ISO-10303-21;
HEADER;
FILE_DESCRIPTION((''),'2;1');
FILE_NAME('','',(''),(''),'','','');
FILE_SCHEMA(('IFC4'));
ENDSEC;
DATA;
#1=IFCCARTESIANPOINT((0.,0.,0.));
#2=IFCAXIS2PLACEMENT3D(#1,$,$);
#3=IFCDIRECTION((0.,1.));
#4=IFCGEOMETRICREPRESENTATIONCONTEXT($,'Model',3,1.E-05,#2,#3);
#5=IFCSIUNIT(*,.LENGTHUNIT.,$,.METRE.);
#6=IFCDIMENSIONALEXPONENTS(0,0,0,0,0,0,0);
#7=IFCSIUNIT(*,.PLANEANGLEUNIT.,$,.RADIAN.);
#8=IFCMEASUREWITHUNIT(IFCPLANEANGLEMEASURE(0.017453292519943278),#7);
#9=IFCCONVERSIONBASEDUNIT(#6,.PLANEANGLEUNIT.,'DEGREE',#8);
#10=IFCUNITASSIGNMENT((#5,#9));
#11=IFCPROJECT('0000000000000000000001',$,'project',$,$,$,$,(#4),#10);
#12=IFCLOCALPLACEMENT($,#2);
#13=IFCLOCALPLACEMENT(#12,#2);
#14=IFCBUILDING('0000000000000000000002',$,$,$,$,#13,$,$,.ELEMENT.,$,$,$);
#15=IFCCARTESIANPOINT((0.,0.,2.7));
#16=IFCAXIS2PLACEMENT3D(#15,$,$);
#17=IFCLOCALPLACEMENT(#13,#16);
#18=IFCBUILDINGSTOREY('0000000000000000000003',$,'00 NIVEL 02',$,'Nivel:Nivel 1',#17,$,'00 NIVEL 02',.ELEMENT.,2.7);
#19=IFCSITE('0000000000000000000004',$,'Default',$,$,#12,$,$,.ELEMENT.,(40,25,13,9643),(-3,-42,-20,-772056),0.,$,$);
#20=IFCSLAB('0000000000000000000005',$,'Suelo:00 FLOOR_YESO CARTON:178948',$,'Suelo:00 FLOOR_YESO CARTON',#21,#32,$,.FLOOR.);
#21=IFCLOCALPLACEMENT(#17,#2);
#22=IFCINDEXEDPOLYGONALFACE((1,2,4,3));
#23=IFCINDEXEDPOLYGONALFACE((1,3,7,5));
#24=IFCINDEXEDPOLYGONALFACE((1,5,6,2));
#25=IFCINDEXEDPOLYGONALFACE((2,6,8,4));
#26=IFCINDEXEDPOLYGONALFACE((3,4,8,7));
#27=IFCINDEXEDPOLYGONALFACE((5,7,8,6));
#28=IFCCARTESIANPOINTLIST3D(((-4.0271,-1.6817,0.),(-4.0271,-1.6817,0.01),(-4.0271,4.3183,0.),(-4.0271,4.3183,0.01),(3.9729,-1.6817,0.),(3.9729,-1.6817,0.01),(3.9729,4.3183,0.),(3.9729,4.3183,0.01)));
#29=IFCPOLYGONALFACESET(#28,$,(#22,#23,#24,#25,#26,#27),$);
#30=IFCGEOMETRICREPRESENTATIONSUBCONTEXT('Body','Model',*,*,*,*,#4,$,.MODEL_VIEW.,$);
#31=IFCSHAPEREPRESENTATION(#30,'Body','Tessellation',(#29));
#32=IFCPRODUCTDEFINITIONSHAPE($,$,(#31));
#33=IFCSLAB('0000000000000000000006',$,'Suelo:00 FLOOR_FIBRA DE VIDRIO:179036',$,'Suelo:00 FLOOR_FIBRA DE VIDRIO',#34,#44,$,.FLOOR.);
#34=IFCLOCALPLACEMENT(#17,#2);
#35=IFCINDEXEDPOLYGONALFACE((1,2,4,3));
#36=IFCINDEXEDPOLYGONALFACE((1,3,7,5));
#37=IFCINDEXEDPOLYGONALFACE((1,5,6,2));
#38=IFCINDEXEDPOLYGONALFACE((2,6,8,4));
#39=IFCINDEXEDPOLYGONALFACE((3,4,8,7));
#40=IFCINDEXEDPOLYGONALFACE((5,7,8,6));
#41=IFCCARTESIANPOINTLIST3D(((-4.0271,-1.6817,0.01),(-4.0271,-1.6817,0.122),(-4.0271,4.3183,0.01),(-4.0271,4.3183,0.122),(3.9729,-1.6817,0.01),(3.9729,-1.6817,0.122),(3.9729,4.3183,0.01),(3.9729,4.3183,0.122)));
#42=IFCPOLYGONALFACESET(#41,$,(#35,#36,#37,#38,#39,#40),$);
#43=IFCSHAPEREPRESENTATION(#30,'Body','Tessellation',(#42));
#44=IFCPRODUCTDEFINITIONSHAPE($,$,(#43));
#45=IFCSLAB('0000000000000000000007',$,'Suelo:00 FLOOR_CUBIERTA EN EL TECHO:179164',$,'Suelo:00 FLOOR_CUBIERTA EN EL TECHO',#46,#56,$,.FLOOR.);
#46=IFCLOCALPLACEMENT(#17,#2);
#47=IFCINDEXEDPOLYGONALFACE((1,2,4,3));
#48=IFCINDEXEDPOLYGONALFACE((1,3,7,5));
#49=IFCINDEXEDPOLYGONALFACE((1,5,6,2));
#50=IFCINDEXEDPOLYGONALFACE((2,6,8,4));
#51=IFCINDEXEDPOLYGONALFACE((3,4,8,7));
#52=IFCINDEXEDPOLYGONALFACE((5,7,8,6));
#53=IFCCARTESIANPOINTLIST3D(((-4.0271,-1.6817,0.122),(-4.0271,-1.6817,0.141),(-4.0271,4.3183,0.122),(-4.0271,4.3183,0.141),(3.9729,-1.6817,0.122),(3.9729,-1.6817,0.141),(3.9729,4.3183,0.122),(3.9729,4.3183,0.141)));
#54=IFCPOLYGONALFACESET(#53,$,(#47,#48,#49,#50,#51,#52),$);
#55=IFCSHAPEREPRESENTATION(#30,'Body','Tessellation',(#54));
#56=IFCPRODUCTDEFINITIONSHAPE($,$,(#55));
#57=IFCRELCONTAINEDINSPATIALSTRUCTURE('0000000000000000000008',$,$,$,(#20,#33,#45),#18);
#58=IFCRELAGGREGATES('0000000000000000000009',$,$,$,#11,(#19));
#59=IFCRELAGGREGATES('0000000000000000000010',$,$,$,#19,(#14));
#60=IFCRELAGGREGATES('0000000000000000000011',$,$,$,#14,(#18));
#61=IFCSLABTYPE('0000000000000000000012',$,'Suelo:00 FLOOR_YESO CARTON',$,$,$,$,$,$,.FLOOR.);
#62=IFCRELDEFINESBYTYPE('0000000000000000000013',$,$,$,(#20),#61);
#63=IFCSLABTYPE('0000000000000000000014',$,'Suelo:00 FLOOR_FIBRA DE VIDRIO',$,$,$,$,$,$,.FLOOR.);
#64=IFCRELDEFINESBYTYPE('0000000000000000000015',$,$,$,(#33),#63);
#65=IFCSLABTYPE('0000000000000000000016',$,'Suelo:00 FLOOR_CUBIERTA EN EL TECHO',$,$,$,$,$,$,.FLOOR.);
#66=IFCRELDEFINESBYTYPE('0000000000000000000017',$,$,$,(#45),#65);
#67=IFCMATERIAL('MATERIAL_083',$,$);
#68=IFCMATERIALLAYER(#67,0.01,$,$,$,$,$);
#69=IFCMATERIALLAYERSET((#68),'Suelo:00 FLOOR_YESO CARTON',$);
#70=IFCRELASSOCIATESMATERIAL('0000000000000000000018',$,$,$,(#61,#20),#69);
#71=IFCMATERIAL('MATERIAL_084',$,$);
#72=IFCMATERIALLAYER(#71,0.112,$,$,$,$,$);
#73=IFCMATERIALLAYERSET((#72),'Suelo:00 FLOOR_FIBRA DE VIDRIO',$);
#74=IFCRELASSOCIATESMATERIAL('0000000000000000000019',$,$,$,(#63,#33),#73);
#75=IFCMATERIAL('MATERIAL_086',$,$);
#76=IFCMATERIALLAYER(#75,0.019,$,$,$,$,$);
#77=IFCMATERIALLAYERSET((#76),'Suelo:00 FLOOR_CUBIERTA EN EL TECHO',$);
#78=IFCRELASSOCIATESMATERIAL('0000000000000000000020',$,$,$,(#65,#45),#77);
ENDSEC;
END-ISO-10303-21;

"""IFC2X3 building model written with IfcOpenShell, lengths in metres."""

from ifc_helpers import new_model, entity, si_unit, converted_unit, direction, frame, origin, origin_2d_with_axis, place, context, subcontext, project, spatial, rectangle, extrude, material, layer, layer_set, layer_usage, type_object, element, save


model = new_model("IFC2X3")

# Units and contexts
model_context = context("Model", 3, precision=1e-05, world=origin(), true_north=direction((0.0, 1.0)))
body_context = subcontext(model_context, "Body", "Model", "MODEL_VIEW")
ifc_project = project(units=[si_unit("LENGTHUNIT", "METRE"), converted_unit("PLANEANGLEUNIT", "DEGREE", entity("IfcPlaneAngleMeasure", 0.017453292519943278), si_unit("PLANEANGLEUNIT", "RADIAN"), dimensions=[0, 0, 0, 0, 0, 0, 0])], contexts=[model_context])

# Site, building, storey
site_placement = place(None, origin())
site = spatial("IfcSite", under=ifc_project, at=site_placement, Name="Default", CompositionType="ELEMENT", RefLatitude=(40, 25, 13, 9643), RefLongitude=(-3, -42, -20, -772056), RefElevation=0.0)
building_placement = place(site_placement, origin())
building = spatial("IfcBuilding", under=site, at=building_placement, CompositionType="ELEMENT")
storey_placement = place(building_placement, frame((0.0, 0.0, 2.7)))
storey = spatial("IfcBuildingStorey", under=building, at=storey_placement, Name="00 NIVEL 02", ObjectType="Nivel:Nivel 1", LongName="00 NIVEL 02", CompositionType="ELEMENT", Elevation=2.7)

# Slabs
ifc_material_1 = material(Name="MATERIAL_083")
ifc_layer_1 = layer(ifc_material_1, 0.01)
ifc_layer_set_1 = layer_set([ifc_layer_1], Name="Suelo:00 FLOOR_YESO CARTON")
ifc_layer_usage_1 = layer_usage(ifc_layer_set_1, "AXIS3", "POSITIVE", 0.0)
slab_type_1 = type_object("IfcSlabType", Name="Suelo:00 FLOOR_YESO CARTON", PredefinedType="FLOOR", material=ifc_layer_set_1)
slab_1_placement = place(storey_placement, origin())
element("IfcSlab", 1, at=slab_1_placement, inside=storey, type_object=slab_type_1, material=ifc_layer_usage_1, Name="Suelo:00 FLOOR_YESO CARTON:178948", ObjectType="Suelo:00 FLOOR_YESO CARTON", PredefinedType="FLOOR", context=body_context, shape_type="SweptSolid", body=[
    extrude(rectangle(XDim=6.0, YDim=8.0, at=origin_2d_with_axis()), frame((-0.0271, 1.3183, 0.01), z_axis=(0.0, 0.0, -1.0), x_axis=(0.0, 1.0, 0.0)), (0.0, 0.0, 1.0), 0.01),
])
ifc_material_2 = material(Name="MATERIAL_084")
ifc_layer_2 = layer(ifc_material_2, 0.112)
ifc_layer_set_2 = layer_set([ifc_layer_2], Name="Suelo:00 FLOOR_FIBRA DE VIDRIO")
ifc_layer_usage_2 = layer_usage(ifc_layer_set_2, "AXIS3", "POSITIVE", 0.0)
slab_type_2 = type_object("IfcSlabType", Name="Suelo:00 FLOOR_FIBRA DE VIDRIO", PredefinedType="FLOOR", material=ifc_layer_set_2)
slab_2_placement = place(storey_placement, origin())
element("IfcSlab", 2, at=slab_2_placement, inside=storey, type_object=slab_type_2, material=ifc_layer_usage_2, Name="Suelo:00 FLOOR_FIBRA DE VIDRIO:179036", ObjectType="Suelo:00 FLOOR_FIBRA DE VIDRIO", PredefinedType="FLOOR", context=body_context, shape_type="SweptSolid", body=[
    extrude(rectangle(XDim=6.0, YDim=8.0, at=origin_2d_with_axis()), frame((-0.0271, 1.3183, 0.122), z_axis=(0.0, 0.0, -1.0), x_axis=(0.0, 1.0, 0.0)), (0.0, 0.0, 1.0), 0.112),
])
ifc_material_3 = material(Name="MATERIAL_086")
ifc_layer_3 = layer(ifc_material_3, 0.019)
ifc_layer_set_3 = layer_set([ifc_layer_3], Name="Suelo:00 FLOOR_CUBIERTA EN EL TECHO")
ifc_layer_usage_3 = layer_usage(ifc_layer_set_3, "AXIS3", "POSITIVE", 0.0)
slab_type_3 = type_object("IfcSlabType", Name="Suelo:00 FLOOR_CUBIERTA EN EL TECHO", PredefinedType="FLOOR", material=ifc_layer_set_3)
slab_3_placement = place(storey_placement, origin())
element("IfcSlab", 3, at=slab_3_placement, inside=storey, type_object=slab_type_3, material=ifc_layer_usage_3, Name="Suelo:00 FLOOR_CUBIERTA EN EL TECHO:179164", ObjectType="Suelo:00 FLOOR_CUBIERTA EN EL TECHO", PredefinedType="FLOOR", context=body_context, shape_type="SweptSolid", body=[
    extrude(rectangle(XDim=6.0, YDim=8.0, at=origin_2d_with_axis()), frame((-0.0271, 1.3183, 0.141), z_axis=(0.0, 0.0, -1.0), x_axis=(0.0, 1.0, 0.0)), (0.0, 0.0, 1.0), 0.019),
])

save(model, "model.ifc")
